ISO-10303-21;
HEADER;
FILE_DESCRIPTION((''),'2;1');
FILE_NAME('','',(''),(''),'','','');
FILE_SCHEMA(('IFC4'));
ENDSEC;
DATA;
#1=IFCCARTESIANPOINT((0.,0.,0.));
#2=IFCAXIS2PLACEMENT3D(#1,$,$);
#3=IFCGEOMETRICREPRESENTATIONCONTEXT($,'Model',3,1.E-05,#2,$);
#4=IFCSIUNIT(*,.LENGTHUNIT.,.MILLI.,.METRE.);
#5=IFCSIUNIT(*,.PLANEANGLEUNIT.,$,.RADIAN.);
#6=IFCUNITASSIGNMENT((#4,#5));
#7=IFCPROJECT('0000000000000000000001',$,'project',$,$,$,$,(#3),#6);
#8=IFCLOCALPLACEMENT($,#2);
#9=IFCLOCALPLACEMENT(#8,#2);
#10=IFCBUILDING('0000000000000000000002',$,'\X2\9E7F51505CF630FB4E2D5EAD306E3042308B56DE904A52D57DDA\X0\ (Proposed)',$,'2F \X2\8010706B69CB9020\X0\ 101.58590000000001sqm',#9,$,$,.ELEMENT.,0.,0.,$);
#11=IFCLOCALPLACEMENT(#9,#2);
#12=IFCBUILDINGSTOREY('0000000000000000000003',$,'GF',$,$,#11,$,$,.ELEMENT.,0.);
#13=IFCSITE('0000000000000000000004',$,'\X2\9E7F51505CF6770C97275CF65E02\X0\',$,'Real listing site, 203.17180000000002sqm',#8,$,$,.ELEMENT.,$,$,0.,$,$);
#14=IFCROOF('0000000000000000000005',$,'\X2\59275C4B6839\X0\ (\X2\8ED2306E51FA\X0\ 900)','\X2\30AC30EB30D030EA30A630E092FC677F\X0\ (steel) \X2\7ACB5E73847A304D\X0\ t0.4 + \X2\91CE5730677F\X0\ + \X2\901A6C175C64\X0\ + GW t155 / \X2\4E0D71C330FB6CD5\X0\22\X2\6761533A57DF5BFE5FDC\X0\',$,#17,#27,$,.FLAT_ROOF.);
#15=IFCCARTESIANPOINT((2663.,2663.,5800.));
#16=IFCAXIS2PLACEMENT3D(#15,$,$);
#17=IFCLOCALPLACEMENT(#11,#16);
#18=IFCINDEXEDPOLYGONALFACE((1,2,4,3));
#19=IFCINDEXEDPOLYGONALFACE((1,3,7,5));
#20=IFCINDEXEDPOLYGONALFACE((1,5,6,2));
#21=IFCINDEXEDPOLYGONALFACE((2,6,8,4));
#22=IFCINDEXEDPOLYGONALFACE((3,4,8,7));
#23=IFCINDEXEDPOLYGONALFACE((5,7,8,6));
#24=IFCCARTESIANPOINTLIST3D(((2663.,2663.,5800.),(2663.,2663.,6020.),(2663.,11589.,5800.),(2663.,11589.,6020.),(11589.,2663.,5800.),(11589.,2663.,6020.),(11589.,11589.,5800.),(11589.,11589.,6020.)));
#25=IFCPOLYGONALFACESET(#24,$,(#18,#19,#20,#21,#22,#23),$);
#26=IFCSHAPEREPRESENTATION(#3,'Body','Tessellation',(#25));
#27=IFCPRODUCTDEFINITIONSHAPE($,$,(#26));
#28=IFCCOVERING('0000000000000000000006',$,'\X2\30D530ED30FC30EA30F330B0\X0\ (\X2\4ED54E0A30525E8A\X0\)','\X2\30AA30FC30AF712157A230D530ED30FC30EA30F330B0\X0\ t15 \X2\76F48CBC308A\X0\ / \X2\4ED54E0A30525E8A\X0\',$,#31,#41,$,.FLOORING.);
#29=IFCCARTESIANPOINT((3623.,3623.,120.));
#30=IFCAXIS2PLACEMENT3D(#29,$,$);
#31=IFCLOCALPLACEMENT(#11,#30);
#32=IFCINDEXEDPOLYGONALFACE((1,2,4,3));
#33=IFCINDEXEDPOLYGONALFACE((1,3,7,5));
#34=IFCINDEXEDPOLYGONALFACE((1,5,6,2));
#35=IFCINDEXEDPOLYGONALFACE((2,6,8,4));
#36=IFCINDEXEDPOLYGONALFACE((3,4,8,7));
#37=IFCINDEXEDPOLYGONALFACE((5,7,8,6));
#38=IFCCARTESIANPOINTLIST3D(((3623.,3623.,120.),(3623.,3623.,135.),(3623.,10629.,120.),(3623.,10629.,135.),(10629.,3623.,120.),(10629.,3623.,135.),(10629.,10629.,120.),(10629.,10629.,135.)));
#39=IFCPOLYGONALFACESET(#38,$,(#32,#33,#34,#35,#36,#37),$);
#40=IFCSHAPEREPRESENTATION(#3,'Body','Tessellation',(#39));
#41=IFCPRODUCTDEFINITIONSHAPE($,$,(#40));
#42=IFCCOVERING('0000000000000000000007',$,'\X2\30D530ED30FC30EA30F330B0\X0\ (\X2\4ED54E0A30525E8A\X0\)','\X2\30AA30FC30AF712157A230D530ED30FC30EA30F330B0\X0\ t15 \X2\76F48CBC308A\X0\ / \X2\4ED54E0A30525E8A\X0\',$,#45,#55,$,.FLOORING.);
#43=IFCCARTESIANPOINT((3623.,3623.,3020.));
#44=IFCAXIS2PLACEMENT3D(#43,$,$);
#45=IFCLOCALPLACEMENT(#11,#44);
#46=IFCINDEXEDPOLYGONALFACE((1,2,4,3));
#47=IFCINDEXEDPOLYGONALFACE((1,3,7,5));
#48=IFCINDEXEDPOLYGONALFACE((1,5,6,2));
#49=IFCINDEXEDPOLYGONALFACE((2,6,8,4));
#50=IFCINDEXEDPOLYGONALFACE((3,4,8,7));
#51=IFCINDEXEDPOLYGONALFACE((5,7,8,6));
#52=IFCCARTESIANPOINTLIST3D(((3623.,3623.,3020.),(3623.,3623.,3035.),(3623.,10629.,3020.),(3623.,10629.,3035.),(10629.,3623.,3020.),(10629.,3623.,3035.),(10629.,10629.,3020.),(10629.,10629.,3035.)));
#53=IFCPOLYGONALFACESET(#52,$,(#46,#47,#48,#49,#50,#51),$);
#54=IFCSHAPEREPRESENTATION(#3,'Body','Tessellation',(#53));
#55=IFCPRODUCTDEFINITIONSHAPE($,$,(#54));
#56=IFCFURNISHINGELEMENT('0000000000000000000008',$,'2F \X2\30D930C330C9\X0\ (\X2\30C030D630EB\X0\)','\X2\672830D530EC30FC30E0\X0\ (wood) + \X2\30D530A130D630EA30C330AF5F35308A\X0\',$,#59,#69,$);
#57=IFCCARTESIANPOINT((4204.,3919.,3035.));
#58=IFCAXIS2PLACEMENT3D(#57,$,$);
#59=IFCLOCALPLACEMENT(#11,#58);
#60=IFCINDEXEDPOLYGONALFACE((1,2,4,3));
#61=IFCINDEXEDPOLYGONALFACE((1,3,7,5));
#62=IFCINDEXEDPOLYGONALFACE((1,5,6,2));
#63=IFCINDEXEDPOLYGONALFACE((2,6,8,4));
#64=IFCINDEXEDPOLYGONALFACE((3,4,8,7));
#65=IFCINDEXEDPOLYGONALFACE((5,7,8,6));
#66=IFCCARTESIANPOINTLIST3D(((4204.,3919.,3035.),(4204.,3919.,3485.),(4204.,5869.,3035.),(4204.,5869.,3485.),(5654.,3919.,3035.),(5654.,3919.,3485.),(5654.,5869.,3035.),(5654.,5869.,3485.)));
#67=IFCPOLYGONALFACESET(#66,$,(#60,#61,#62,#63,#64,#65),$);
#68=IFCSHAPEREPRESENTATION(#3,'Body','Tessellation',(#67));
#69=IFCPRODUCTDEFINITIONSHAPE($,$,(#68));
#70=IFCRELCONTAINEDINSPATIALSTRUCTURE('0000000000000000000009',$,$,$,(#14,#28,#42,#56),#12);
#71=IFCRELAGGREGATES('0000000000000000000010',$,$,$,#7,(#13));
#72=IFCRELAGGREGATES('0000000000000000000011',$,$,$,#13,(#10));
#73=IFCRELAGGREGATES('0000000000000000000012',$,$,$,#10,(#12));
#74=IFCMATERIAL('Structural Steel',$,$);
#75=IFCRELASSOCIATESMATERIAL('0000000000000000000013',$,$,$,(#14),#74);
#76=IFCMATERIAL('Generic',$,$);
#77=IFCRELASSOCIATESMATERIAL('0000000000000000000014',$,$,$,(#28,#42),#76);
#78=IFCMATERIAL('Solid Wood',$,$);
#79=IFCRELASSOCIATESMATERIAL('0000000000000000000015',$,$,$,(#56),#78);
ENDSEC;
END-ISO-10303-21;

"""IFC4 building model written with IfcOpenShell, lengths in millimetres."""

from ifc_helpers import new_model, si_unit, frame, frame_2d, origin, place, context, project, spatial, rectangle, extrude, material, element, save


model = new_model("IFC4")

# Units and contexts
model_context = context("Model", 3, precision=1e-05, world=origin())
ifc_project = project(units=[si_unit("LENGTHUNIT", "METRE", prefix="MILLI"), si_unit("PLANEANGLEUNIT", "RADIAN")], contexts=[model_context])

# Site, building, storey
site_placement = place(None, origin())
site = spatial("IfcSite", under=ifc_project, at=site_placement, Name="鹿児島県霧島市", ObjectType="Real listing site, 203.17180000000002sqm", CompositionType="ELEMENT", RefElevation=0.0)
building_placement = place(site_placement, origin())
building = spatial("IfcBuilding", under=site, at=building_placement, Name="鹿児島・中庭のある回遊動線 (Proposed)", ObjectType="2F 耐火構造 101.58590000000001sqm", CompositionType="ELEMENT", ElevationOfRefHeight=0.0, ElevationOfTerrain=0.0)
storey_placement = place(building_placement, origin())
storey = spatial("IfcBuildingStorey", under=building, at=storey_placement, Name="GF", CompositionType="ELEMENT", Elevation=0.0)

# Shared definitions
ifc_material_1 = material(Name="Solid Wood")

# Roof
ifc_material_2 = material(Name="Structural Steel")
roof_placement = place(storey_placement, frame((2663.0, 2663.0, 5800.0)))
element("IfcRoof", 1, at=roof_placement, inside=storey, material=ifc_material_2, Name="大屋根 (軒の出 900)", Description="ガルバリウム鋼板 (steel) 立平葺き t0.4 + 野地板 + 通気層 + GW t155 / 不燃・法22条区域対応", PredefinedType="FLAT_ROOF", context=model_context, shape_type="SweptSolid", body=[
    extrude(rectangle(XDim=8926.0, YDim=8926.0, at=frame_2d((4463.0, 4463.0))), frame((2663.0, 2663.0, 5800.0)), (0.0, 0.0, 1.0), 220.0),
])

# Coverings
ifc_material_3 = material(Name="Generic")
covering_1_placement = place(storey_placement, frame((3623.0, 3623.0, 120.0)))
element("IfcCovering", 2, at=covering_1_placement, inside=storey, material=ifc_material_3, Name="フローリング (仕上げ床)", Description="オーク無垢フローリング t15 直貼り / 仕上げ床", PredefinedType="FLOORING", context=model_context, shape_type="SweptSolid", body=[
    extrude(rectangle(XDim=7006.0, YDim=7006.0, at=frame_2d((3503.0, 3503.0))), frame((3623.0, 3623.0, 120.0)), (0.0, 0.0, 1.0), 15.0),
])
covering_2_placement = place(storey_placement, frame((3623.0, 3623.0, 3020.0)))
element("IfcCovering", 3, at=covering_2_placement, inside=storey, material=ifc_material_3, Name="フローリング (仕上げ床)", Description="オーク無垢フローリング t15 直貼り / 仕上げ床", PredefinedType="FLOORING", context=model_context, shape_type="SweptSolid", body=[
    extrude(rectangle(XDim=7006.0, YDim=7006.0, at=frame_2d((3503.0, 3503.0))), frame((3623.0, 3623.0, 3020.0)), (0.0, 0.0, 1.0), 15.0),
])

# Furnishing element
furnishing_placement = place(storey_placement, frame((4204.0, 3919.0, 3035.0)))
element("IfcFurnishingElement", 4, at=furnishing_placement, inside=storey, material=ifc_material_1, Name="2F ベッド (ダブル)", Description="木フレーム (wood) + ファブリック張り", context=model_context, shape_type="SweptSolid", body=[
    extrude(rectangle(XDim=1450.0, YDim=1950.0, at=frame_2d((725.0, 975.0))), frame((4204.0, 3919.0, 3035.0)), (0.0, 0.0, 1.0), 450.0),
])

save(model, "model.ifc")
